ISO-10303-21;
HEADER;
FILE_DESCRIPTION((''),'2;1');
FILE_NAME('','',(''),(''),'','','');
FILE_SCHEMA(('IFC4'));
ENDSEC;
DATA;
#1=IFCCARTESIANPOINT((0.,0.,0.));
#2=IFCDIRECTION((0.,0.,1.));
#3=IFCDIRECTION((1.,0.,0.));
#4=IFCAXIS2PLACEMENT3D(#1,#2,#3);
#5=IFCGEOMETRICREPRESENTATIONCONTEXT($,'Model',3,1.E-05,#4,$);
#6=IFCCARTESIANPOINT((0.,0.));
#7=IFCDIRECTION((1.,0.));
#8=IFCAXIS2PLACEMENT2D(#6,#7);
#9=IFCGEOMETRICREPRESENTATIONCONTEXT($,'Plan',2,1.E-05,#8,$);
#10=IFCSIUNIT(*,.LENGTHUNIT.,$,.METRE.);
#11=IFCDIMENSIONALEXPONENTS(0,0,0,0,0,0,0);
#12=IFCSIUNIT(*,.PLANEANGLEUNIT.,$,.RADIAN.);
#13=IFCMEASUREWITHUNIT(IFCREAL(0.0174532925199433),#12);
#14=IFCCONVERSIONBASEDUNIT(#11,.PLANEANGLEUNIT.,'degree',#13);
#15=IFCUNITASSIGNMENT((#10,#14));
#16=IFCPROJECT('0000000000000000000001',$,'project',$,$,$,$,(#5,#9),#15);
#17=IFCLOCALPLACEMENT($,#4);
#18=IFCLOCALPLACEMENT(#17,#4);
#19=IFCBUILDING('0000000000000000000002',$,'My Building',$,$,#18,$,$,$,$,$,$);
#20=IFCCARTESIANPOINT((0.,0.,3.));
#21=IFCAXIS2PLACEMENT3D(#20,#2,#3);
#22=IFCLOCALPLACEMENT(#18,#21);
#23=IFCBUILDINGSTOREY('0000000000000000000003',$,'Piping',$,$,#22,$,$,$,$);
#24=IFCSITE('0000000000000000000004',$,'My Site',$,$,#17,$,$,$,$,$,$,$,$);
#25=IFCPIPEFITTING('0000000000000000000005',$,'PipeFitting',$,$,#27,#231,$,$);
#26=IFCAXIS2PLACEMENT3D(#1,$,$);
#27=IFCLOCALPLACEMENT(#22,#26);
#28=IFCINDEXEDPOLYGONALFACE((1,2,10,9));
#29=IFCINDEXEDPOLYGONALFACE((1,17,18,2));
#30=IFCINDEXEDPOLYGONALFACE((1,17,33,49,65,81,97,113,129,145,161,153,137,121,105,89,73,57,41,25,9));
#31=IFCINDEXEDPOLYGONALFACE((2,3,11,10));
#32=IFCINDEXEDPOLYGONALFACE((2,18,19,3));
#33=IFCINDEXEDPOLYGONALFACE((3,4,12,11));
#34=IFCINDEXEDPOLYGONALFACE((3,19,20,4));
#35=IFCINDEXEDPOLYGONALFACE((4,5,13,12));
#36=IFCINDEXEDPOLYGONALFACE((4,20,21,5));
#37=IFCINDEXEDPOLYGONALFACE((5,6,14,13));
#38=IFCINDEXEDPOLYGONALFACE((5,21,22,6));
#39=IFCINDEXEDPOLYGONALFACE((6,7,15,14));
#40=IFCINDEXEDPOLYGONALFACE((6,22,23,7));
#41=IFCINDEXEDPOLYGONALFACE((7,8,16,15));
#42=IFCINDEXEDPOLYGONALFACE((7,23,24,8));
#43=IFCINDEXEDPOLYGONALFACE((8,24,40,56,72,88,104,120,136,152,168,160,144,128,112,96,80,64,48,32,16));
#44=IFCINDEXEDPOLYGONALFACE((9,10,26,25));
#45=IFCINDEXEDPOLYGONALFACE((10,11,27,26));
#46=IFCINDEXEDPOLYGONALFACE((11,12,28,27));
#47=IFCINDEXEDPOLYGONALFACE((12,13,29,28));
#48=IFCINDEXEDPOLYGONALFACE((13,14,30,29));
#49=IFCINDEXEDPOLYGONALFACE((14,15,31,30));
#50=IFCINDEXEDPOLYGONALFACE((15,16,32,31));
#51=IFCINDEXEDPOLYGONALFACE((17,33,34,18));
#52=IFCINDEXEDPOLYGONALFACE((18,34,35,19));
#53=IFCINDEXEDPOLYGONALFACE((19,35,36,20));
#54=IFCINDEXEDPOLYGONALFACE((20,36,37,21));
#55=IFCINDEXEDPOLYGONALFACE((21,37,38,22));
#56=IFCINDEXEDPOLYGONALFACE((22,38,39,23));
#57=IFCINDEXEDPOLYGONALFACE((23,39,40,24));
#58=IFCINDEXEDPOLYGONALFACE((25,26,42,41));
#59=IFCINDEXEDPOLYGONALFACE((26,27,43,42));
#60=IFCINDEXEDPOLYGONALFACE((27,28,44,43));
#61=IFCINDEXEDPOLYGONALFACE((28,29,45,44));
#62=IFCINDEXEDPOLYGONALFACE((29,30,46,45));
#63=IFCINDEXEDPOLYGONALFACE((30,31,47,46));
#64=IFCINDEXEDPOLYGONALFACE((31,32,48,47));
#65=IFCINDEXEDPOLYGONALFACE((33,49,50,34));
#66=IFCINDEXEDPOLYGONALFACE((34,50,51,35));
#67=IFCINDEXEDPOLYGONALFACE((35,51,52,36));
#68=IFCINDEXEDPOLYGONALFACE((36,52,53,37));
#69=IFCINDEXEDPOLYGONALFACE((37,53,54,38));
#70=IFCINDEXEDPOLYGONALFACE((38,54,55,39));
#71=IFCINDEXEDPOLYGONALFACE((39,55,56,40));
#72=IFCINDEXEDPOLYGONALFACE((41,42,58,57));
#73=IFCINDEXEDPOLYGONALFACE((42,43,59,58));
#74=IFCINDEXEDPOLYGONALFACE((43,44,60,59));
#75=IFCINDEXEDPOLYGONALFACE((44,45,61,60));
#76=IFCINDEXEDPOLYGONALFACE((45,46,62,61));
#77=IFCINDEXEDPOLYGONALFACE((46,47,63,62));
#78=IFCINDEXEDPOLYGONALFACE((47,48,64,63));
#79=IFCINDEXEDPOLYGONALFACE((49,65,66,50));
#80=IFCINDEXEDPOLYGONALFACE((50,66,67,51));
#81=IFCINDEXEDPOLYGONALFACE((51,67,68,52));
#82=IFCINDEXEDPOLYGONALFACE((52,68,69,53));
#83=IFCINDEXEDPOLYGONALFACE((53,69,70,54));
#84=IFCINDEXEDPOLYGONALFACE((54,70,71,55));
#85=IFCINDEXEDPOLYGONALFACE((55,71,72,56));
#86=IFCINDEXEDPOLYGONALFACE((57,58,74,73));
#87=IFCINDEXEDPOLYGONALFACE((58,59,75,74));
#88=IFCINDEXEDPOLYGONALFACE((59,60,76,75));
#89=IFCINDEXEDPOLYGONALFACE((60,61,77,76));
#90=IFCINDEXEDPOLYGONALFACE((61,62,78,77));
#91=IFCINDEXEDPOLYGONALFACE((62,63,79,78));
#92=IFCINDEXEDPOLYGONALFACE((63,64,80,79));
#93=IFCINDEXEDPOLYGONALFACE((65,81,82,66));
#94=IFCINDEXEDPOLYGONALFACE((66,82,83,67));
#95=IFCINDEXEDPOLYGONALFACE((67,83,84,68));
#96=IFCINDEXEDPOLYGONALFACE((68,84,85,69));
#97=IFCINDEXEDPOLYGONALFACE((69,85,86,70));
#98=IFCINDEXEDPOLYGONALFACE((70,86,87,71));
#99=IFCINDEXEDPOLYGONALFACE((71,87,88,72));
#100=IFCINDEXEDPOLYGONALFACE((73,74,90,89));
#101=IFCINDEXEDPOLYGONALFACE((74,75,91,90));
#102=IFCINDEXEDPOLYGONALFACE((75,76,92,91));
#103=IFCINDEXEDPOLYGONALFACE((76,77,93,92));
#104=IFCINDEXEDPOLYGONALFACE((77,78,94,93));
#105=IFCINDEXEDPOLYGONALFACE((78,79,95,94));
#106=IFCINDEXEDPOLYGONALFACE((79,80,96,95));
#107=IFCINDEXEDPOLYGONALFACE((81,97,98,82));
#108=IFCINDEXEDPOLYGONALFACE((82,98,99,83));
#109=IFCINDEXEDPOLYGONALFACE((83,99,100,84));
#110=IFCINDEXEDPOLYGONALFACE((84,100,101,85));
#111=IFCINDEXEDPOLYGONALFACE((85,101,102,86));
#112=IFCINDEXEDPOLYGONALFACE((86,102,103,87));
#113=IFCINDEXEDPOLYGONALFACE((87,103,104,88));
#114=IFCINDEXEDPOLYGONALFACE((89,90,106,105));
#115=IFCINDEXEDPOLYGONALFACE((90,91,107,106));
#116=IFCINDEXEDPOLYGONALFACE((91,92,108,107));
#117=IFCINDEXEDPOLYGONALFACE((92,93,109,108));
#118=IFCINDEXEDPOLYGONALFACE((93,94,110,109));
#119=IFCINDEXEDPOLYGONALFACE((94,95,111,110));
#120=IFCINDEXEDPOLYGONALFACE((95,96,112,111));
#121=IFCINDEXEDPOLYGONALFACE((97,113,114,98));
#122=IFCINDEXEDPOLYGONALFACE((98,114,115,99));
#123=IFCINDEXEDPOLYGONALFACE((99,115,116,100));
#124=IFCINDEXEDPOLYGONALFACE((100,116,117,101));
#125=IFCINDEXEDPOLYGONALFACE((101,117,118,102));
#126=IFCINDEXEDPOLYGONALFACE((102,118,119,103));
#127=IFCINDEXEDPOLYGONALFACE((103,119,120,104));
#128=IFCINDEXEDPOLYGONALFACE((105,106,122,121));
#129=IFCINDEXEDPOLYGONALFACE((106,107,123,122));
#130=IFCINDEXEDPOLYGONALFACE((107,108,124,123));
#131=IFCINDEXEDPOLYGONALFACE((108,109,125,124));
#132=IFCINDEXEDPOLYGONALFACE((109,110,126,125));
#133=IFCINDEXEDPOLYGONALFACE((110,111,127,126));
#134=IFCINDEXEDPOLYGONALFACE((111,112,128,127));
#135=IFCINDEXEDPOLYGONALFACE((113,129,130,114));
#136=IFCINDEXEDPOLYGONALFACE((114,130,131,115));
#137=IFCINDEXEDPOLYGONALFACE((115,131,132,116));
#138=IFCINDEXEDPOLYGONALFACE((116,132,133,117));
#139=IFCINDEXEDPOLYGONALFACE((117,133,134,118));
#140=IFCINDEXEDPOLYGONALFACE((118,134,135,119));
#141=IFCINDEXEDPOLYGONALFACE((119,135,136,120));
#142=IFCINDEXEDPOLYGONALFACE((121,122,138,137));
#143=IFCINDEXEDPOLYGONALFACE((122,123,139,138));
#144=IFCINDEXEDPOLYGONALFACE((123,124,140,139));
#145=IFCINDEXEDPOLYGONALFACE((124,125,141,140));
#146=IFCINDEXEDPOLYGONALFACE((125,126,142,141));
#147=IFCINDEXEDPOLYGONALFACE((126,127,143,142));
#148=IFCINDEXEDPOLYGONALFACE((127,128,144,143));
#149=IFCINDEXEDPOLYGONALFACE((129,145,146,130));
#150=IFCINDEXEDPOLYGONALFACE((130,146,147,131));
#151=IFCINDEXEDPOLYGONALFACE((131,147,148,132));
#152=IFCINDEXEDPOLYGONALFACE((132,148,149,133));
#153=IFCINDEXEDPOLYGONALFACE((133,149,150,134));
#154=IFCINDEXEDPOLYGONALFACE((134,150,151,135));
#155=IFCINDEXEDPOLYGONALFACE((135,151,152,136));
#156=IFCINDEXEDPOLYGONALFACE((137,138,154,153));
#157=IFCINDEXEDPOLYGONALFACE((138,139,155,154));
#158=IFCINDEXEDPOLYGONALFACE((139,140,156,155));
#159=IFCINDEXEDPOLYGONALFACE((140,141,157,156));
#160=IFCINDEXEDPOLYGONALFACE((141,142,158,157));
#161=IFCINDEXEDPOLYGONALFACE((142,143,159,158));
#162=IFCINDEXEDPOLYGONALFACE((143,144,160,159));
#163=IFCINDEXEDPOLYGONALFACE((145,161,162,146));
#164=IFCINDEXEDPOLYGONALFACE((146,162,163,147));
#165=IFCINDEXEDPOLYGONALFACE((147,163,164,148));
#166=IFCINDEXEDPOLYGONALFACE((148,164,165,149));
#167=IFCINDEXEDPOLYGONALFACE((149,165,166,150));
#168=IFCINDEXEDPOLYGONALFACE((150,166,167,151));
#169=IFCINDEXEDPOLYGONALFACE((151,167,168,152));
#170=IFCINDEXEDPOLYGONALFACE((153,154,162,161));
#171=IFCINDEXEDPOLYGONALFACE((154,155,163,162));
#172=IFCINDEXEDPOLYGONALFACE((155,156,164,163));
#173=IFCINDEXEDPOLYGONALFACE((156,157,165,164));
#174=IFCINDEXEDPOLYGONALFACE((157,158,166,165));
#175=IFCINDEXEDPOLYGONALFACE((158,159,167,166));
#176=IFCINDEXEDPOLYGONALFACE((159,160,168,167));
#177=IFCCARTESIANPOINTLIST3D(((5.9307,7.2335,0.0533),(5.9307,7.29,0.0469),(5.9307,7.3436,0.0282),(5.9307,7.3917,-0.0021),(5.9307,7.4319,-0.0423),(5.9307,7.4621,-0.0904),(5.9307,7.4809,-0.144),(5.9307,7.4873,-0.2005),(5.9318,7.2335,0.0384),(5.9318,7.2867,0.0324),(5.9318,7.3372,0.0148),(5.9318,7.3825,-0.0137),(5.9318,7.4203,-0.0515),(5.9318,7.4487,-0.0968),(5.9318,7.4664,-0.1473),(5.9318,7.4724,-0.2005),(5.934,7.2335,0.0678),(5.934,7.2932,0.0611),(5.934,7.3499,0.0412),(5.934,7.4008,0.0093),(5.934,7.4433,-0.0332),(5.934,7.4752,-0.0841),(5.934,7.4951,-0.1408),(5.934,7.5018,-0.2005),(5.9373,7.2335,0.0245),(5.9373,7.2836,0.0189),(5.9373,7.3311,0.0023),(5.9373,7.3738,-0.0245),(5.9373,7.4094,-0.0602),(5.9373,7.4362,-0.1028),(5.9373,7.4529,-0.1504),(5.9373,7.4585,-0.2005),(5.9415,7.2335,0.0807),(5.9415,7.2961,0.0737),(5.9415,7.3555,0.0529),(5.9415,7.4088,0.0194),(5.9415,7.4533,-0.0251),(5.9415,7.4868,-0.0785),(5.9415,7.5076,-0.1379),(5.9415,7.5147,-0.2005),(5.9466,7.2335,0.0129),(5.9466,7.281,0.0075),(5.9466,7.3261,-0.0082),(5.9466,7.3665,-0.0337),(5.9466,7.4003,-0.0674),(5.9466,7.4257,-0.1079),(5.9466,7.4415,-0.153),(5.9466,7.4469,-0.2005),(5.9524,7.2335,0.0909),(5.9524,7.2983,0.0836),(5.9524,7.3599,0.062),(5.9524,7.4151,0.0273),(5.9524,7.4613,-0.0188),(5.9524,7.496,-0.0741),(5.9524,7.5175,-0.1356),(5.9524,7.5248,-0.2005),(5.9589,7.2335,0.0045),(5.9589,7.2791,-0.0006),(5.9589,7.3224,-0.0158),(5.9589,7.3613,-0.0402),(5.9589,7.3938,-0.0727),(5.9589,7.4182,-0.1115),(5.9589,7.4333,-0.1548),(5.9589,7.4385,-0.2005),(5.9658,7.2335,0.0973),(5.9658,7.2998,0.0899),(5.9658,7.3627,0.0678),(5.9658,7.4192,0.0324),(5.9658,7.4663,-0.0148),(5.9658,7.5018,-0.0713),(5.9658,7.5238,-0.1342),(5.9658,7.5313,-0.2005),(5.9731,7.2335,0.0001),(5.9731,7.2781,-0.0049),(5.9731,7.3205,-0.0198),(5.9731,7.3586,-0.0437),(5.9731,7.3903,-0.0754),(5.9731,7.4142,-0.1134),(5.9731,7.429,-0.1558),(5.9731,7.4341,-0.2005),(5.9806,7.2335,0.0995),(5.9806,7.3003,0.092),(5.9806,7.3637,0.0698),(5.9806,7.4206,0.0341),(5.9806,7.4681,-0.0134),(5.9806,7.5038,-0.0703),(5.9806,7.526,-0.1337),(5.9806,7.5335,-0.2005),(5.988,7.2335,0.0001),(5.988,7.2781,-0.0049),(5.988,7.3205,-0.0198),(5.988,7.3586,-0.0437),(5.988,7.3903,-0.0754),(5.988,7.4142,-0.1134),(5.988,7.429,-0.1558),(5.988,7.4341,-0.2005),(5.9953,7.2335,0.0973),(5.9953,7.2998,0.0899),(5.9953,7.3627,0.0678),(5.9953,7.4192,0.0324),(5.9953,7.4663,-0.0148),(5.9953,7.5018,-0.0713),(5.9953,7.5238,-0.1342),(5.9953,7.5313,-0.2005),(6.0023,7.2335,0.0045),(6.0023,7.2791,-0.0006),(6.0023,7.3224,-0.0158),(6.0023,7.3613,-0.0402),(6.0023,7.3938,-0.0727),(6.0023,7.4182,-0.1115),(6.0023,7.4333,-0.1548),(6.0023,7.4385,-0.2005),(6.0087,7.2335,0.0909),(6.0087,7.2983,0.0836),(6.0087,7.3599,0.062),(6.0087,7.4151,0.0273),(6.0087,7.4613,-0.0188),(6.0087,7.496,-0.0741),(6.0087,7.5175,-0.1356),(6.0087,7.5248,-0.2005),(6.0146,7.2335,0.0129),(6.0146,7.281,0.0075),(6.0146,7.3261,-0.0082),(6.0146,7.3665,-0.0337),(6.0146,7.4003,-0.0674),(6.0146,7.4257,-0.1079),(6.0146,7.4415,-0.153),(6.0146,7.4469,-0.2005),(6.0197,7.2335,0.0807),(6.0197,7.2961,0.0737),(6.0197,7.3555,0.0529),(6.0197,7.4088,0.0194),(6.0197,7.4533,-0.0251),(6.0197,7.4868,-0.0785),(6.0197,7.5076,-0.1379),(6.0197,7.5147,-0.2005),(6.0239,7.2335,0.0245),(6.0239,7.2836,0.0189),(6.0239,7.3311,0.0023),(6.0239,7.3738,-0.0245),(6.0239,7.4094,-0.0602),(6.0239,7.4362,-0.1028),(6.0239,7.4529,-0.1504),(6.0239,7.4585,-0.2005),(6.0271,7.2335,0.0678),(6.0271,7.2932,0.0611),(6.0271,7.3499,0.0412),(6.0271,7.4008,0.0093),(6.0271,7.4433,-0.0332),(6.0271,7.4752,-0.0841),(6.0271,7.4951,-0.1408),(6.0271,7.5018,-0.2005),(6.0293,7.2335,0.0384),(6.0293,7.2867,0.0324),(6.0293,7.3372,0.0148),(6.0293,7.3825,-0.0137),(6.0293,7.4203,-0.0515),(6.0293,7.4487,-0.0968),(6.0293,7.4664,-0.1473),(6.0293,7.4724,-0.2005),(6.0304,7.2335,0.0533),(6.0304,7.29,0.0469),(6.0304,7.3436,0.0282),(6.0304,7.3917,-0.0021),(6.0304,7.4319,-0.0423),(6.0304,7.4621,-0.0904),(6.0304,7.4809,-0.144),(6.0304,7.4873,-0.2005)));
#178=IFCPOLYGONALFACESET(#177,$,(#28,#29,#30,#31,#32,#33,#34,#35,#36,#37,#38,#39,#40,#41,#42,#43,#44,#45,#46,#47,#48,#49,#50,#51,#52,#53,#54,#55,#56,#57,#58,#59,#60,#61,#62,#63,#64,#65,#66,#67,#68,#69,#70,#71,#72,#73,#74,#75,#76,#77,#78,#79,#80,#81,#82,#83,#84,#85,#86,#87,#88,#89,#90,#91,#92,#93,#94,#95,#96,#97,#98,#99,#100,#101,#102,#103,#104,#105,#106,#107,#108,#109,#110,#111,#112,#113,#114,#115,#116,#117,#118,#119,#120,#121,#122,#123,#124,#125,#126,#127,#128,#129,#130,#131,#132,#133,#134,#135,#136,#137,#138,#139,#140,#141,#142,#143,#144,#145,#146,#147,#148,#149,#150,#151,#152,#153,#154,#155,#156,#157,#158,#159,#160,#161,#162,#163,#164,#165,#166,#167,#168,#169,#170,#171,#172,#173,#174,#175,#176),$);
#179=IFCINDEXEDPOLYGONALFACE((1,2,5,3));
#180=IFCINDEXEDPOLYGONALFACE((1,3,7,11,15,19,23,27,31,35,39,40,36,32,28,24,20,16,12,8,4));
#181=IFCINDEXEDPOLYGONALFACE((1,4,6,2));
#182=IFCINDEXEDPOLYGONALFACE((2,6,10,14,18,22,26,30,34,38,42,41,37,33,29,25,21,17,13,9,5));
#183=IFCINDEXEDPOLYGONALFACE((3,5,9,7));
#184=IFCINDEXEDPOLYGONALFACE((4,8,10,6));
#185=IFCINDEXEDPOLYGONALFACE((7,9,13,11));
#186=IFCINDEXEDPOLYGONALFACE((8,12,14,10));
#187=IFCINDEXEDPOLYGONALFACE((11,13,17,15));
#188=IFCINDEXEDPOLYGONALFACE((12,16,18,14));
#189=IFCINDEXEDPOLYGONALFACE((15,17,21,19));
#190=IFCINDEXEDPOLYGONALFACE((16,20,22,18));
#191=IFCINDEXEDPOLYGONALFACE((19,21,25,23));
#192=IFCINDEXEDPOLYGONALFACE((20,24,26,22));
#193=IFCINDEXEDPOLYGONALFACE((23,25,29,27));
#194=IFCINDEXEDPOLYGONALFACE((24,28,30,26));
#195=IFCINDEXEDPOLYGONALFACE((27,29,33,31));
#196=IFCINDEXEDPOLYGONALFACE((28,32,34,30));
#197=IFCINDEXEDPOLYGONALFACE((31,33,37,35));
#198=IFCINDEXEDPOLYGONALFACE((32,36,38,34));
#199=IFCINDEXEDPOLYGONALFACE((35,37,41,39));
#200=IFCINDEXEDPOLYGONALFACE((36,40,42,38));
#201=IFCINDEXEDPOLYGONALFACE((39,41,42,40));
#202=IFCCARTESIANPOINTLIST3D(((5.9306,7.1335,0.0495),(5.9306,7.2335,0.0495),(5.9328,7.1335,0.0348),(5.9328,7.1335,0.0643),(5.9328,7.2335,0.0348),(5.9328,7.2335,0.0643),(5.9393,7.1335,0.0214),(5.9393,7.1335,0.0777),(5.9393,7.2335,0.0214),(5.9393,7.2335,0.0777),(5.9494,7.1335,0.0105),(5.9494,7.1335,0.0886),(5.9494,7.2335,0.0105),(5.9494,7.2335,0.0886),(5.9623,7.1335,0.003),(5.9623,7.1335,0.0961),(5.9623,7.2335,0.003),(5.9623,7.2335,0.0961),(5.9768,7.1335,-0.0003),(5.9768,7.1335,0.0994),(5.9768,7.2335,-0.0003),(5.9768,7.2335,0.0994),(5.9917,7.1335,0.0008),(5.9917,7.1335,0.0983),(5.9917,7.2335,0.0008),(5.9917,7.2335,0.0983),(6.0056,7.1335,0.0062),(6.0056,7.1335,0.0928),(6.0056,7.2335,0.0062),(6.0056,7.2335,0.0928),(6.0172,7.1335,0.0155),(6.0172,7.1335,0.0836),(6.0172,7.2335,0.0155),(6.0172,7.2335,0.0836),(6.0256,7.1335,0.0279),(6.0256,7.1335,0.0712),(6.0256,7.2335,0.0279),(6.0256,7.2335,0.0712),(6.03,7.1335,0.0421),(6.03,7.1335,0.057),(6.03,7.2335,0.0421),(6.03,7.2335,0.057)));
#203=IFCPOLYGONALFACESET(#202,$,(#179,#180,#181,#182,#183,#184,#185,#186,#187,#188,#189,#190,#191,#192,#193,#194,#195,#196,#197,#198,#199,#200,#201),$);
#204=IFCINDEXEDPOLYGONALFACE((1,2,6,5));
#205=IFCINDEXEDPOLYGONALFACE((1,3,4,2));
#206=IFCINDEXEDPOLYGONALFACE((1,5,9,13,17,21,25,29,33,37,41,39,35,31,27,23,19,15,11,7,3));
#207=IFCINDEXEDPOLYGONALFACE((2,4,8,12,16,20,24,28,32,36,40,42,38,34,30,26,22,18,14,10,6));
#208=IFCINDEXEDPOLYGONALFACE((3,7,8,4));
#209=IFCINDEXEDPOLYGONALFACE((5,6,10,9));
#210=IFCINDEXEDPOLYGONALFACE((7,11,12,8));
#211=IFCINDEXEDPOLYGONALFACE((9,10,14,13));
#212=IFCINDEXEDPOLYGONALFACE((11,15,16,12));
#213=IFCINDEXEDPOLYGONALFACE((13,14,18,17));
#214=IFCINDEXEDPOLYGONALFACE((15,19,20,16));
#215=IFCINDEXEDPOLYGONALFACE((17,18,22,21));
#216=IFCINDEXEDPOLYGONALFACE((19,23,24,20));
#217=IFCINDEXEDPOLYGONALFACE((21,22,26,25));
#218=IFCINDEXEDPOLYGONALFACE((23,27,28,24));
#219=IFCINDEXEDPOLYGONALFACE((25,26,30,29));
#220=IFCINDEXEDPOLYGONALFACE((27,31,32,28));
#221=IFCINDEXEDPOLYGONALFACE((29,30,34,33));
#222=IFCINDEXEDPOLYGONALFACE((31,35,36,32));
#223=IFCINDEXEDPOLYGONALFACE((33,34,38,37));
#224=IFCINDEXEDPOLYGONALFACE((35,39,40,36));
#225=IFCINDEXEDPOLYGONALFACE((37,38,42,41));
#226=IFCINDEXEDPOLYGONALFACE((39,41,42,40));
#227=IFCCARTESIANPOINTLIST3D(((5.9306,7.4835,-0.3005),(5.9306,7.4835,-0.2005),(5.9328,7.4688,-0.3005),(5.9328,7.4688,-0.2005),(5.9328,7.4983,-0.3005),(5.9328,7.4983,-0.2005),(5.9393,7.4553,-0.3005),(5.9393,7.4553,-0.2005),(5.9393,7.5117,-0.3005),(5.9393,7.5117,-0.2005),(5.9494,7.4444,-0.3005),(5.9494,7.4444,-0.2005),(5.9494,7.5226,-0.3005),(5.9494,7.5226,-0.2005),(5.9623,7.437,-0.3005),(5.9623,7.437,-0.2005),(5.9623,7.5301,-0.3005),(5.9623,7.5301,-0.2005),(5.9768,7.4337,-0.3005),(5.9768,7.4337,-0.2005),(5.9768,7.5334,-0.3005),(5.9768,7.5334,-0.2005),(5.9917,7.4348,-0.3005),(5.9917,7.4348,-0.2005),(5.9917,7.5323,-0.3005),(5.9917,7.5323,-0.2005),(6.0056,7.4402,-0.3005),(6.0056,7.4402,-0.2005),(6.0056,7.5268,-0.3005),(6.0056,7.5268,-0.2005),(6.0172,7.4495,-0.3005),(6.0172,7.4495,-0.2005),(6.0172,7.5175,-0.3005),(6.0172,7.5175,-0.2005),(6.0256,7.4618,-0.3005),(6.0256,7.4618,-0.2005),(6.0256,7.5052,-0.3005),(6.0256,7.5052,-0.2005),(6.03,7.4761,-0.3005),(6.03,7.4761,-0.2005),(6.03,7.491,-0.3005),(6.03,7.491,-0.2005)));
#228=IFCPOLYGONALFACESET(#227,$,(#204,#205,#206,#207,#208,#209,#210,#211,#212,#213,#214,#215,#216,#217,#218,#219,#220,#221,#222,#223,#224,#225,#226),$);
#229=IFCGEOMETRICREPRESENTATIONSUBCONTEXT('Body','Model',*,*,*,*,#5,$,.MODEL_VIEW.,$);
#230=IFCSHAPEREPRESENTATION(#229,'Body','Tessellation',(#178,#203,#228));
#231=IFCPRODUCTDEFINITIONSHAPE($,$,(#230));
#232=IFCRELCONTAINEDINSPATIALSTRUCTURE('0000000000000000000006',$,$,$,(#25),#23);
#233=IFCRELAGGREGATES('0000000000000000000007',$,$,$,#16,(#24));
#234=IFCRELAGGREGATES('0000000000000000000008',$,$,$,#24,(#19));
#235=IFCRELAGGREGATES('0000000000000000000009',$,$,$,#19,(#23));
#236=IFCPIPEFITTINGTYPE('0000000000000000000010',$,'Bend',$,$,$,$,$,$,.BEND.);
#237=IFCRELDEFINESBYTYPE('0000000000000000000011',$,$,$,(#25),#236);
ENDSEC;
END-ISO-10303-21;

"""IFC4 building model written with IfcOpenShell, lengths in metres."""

from ifc_helpers import new_model, entity, si_unit, converted_unit, frame, origin_with_axes, origin_2d_with_axis, place, context, subcontext, project, spatial, circle, extrude, source, transform, mapped, type_object, type_shapes, element, save


model = new_model("IFC4")

# Units and contexts
model_context = context("Model", 3, precision=1e-05, world=origin_with_axes())
plan_context = context("Plan", 2, precision=1e-05, world=origin_2d_with_axis())
body_context = subcontext(model_context, "Body", "Model", "MODEL_VIEW")
ifc_project = project(units=[si_unit("LENGTHUNIT", "METRE"), converted_unit("PLANEANGLEUNIT", "degree", entity("IfcReal", 0.0174532925199433), si_unit("PLANEANGLEUNIT", "RADIAN"), dimensions=[0, 0, 0, 0, 0, 0, 0])], contexts=[model_context, plan_context])

# Site, building, storey
site_placement = place(None, origin_with_axes())
site = spatial("IfcSite", under=ifc_project, at=site_placement, Name="My Site")
building_placement = place(site_placement, origin_with_axes())
building = spatial("IfcBuilding", under=site, at=building_placement, Name="My Building")
storey_placement = place(building_placement, frame((0.0, 0.0, 3.0), z_axis=(0.0, 0.0, 1.0), x_axis=(1.0, 0.0, 0.0)))
storey = spatial("IfcBuildingStorey", under=building, at=storey_placement, Name="Piping")

# Pipe fitting
pipe_fitting_type = type_object("IfcPipeFittingType", Name="Bend", PredefinedType="BEND")
shared_shape = source(origin_with_axes(), body_context, "Body", "SolidModel", [
    entity("IfcSweptDiskSolid", entity("IfcIndexedPolyCurve", entity("IfcCartesianPointList3D", [[0.0, 0.0, 0.1], [0.0, -0.0732, 0.2768], [0.0, -0.25, 0.35]]), [entity("IfcArcIndex", [1, 2, 3])]), 0.05),
    extrude(circle(Radius=0.05), origin_with_axes(), (0.0, 0.0, 1.0), 0.1),
    extrude(circle(Radius=0.05), frame((0.0, -0.25, 0.35), z_axis=(0.0, -1.0, 0.0), x_axis=(1.0, 0.0, 0.0)), (0.0, 0.0, 1.0), 0.1),
])
type_shapes(pipe_fitting_type, [shared_shape])
for number, where, z_axis, x_axis, name in (
    (1, (5.9806, 7.1335, 0.0495), (0.0, 1.0, 0.0), (-1.0, 0.0, 0.0), "PipeFitting"),
):
    element("IfcPipeFitting", number, at=place(storey_placement, frame(where, z_axis=z_axis, x_axis=x_axis)), inside=storey, type_object=pipe_fitting_type, Name=name, context=body_context, shape_type="MappedRepresentation", body=[
        mapped(shared_shape, transform((0.0, 0.0, 0.0), x_axis=(1.0, 0.0, 0.0), y_axis=(0.0, 1.0, 0.0), z_axis=(0.0, 0.0, 1.0), scale=1.0)),
    ])

save(model, "model.ifc")
